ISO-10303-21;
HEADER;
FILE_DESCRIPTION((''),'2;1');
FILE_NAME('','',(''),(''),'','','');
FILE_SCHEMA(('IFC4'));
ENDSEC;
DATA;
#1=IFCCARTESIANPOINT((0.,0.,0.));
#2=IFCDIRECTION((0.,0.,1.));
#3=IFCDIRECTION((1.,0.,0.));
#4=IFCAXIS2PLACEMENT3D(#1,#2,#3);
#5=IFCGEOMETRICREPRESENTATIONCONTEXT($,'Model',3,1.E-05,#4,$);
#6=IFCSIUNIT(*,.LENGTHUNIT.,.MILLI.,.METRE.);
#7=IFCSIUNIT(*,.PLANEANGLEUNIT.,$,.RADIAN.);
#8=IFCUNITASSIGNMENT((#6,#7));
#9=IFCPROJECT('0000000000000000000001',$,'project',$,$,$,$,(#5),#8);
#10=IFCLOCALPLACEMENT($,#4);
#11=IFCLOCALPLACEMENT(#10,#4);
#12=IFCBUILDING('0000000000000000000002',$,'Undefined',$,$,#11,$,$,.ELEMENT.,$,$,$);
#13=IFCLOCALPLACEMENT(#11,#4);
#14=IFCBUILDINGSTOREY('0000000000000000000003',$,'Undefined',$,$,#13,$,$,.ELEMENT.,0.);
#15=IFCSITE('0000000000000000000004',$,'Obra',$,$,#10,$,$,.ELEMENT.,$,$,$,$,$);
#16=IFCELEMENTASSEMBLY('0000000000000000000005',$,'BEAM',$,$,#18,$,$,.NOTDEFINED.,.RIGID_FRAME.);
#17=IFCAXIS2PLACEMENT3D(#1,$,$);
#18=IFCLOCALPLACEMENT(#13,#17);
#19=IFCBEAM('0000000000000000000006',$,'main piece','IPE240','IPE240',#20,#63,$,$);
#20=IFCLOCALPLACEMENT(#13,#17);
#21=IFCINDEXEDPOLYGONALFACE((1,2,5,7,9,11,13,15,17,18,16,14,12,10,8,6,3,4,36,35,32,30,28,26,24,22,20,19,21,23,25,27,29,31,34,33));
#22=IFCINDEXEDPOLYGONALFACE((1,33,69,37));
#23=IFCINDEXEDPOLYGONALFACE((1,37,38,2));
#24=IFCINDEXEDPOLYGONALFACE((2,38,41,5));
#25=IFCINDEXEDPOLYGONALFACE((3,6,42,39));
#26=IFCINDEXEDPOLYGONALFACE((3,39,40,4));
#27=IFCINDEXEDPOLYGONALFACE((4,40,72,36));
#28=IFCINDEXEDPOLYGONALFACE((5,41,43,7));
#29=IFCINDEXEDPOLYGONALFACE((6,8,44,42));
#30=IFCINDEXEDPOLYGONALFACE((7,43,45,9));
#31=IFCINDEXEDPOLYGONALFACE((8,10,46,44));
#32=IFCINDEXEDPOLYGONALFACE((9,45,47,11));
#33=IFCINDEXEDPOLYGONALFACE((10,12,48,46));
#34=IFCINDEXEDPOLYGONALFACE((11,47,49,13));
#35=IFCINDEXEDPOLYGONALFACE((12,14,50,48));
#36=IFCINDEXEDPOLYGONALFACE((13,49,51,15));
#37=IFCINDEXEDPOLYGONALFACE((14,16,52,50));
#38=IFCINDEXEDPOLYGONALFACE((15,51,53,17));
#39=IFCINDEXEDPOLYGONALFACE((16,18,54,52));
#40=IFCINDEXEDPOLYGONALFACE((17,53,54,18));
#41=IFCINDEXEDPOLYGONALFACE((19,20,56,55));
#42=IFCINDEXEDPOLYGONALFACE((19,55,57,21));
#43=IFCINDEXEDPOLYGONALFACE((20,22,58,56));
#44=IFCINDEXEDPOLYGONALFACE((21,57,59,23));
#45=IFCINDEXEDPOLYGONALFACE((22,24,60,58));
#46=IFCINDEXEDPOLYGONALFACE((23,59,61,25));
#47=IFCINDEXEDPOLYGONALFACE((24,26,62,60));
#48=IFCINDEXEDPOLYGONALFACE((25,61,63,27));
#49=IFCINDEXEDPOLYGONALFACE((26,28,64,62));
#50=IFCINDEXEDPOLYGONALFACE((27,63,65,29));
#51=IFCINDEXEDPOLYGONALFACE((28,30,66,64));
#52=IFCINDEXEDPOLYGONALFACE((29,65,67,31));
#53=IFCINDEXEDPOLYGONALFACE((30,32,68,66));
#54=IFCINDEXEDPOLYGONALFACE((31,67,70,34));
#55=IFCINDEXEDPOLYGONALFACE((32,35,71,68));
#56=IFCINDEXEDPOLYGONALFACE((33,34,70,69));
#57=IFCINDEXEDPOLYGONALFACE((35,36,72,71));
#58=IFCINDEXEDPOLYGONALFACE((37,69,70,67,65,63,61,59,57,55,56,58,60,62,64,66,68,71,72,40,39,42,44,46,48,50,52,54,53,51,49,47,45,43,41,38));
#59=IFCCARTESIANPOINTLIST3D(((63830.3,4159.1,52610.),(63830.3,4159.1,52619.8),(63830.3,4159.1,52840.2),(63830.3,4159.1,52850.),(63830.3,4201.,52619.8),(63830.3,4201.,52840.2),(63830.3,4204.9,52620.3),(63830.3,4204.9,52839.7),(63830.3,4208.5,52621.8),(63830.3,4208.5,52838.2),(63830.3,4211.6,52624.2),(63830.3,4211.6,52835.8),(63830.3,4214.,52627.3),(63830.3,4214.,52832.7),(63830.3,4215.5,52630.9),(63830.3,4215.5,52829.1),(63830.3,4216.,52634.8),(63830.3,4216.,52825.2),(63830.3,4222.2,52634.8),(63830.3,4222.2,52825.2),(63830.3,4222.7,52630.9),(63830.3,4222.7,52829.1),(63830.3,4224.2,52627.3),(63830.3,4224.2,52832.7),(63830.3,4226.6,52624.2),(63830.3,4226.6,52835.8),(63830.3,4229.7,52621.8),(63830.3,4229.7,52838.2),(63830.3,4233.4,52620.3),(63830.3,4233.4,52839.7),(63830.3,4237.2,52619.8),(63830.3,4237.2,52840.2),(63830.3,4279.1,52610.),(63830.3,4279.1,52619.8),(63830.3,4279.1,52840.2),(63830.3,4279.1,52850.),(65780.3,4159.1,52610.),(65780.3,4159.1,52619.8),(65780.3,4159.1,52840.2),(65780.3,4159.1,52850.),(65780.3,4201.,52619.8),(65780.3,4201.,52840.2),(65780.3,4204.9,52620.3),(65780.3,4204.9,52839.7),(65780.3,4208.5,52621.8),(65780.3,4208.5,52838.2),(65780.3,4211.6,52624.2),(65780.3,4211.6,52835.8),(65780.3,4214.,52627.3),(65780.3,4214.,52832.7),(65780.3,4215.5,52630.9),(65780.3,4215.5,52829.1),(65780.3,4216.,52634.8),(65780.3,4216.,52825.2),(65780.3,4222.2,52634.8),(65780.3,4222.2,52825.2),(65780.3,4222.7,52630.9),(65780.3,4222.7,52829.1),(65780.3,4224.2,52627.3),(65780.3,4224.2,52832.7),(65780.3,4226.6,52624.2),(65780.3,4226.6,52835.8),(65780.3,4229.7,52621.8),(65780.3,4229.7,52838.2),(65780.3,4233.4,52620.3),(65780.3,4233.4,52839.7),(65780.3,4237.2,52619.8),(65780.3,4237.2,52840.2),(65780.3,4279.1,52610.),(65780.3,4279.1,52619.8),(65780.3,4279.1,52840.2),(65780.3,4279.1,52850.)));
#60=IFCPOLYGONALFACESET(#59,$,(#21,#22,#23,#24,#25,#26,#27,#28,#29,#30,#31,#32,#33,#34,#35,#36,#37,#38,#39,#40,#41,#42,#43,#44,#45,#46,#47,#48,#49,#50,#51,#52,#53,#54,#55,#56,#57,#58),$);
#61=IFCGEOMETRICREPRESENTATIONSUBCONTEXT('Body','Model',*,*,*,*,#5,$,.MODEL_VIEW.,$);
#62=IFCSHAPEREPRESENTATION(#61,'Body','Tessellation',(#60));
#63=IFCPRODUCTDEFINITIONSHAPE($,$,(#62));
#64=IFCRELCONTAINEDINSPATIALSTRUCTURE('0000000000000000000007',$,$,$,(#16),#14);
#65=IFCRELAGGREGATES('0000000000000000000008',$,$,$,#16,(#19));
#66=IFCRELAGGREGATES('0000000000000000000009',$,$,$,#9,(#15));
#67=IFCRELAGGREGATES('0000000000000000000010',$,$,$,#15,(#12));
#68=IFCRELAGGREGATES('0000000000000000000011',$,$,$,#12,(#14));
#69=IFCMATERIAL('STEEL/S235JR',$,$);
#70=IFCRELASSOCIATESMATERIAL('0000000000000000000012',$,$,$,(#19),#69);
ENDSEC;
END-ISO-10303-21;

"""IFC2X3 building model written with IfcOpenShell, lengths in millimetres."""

from ifc_helpers import new_model, si_unit, frame, origin_with_axes, origin_2d_with_axis, place, context, subcontext, project, spatial, i_section, extrude, material, element, aggregate, save


model = new_model("IFC2X3")

# Units and contexts
model_context = context("Model", 3, precision=1e-05, world=origin_with_axes())
body_context = subcontext(model_context, "Body", "Model", "MODEL_VIEW")
ifc_project = project(units=[si_unit("LENGTHUNIT", "METRE", prefix="MILLI"), si_unit("PLANEANGLEUNIT", "RADIAN")], contexts=[model_context])

# Site, building, storey
site_placement = place(None, origin_with_axes())
site = spatial("IfcSite", under=ifc_project, at=site_placement, Name="Obra", CompositionType="ELEMENT")
building_placement = place(site_placement, origin_with_axes())
building = spatial("IfcBuilding", under=site, at=building_placement, Name="Undefined", CompositionType="ELEMENT")
storey_placement = place(building_placement, origin_with_axes())
storey = spatial("IfcBuildingStorey", under=building, at=storey_placement, Name="Undefined", CompositionType="ELEMENT", Elevation=0.0)

# Shared definitions
ifc_material_1 = material(Name="STEEL/S235JR")

# Element assembly, beam
assembly_1_placement = place(storey_placement, origin_with_axes())
assembly_1 = element("IfcElementAssembly", 1, at=assembly_1_placement, inside=storey, Name="BEAM", AssemblyPlace="NOTDEFINED", PredefinedType="RIGID_FRAME")
beam_1_placement = place(assembly_1_placement, frame((63830.3, 4219.1, 52730.0), z_axis=(0.0, 0.0, 1.0), x_axis=(1.0, 0.0, 0.0)))
beam_1 = element("IfcBeam", 2, at=beam_1_placement, material=ifc_material_1, Name="main piece", Description="IPE240", ObjectType="IPE240", context=body_context, shape_type="SweptSolid", body=[
    extrude(i_section(OverallWidth=120.0, OverallDepth=240.0, WebThickness=6.2, FlangeThickness=9.8, FilletRadius=15.0, at=origin_2d_with_axis()), frame((1950.0, 0.0, 0.0), z_axis=(-1.0, 0.0, 0.0), x_axis=(0.0, -1.0, 0.0)), (0.0, 0.0, 1.0), 1950.0),
])
aggregate(assembly_1, [beam_1])

save(model, "model.ifc")
